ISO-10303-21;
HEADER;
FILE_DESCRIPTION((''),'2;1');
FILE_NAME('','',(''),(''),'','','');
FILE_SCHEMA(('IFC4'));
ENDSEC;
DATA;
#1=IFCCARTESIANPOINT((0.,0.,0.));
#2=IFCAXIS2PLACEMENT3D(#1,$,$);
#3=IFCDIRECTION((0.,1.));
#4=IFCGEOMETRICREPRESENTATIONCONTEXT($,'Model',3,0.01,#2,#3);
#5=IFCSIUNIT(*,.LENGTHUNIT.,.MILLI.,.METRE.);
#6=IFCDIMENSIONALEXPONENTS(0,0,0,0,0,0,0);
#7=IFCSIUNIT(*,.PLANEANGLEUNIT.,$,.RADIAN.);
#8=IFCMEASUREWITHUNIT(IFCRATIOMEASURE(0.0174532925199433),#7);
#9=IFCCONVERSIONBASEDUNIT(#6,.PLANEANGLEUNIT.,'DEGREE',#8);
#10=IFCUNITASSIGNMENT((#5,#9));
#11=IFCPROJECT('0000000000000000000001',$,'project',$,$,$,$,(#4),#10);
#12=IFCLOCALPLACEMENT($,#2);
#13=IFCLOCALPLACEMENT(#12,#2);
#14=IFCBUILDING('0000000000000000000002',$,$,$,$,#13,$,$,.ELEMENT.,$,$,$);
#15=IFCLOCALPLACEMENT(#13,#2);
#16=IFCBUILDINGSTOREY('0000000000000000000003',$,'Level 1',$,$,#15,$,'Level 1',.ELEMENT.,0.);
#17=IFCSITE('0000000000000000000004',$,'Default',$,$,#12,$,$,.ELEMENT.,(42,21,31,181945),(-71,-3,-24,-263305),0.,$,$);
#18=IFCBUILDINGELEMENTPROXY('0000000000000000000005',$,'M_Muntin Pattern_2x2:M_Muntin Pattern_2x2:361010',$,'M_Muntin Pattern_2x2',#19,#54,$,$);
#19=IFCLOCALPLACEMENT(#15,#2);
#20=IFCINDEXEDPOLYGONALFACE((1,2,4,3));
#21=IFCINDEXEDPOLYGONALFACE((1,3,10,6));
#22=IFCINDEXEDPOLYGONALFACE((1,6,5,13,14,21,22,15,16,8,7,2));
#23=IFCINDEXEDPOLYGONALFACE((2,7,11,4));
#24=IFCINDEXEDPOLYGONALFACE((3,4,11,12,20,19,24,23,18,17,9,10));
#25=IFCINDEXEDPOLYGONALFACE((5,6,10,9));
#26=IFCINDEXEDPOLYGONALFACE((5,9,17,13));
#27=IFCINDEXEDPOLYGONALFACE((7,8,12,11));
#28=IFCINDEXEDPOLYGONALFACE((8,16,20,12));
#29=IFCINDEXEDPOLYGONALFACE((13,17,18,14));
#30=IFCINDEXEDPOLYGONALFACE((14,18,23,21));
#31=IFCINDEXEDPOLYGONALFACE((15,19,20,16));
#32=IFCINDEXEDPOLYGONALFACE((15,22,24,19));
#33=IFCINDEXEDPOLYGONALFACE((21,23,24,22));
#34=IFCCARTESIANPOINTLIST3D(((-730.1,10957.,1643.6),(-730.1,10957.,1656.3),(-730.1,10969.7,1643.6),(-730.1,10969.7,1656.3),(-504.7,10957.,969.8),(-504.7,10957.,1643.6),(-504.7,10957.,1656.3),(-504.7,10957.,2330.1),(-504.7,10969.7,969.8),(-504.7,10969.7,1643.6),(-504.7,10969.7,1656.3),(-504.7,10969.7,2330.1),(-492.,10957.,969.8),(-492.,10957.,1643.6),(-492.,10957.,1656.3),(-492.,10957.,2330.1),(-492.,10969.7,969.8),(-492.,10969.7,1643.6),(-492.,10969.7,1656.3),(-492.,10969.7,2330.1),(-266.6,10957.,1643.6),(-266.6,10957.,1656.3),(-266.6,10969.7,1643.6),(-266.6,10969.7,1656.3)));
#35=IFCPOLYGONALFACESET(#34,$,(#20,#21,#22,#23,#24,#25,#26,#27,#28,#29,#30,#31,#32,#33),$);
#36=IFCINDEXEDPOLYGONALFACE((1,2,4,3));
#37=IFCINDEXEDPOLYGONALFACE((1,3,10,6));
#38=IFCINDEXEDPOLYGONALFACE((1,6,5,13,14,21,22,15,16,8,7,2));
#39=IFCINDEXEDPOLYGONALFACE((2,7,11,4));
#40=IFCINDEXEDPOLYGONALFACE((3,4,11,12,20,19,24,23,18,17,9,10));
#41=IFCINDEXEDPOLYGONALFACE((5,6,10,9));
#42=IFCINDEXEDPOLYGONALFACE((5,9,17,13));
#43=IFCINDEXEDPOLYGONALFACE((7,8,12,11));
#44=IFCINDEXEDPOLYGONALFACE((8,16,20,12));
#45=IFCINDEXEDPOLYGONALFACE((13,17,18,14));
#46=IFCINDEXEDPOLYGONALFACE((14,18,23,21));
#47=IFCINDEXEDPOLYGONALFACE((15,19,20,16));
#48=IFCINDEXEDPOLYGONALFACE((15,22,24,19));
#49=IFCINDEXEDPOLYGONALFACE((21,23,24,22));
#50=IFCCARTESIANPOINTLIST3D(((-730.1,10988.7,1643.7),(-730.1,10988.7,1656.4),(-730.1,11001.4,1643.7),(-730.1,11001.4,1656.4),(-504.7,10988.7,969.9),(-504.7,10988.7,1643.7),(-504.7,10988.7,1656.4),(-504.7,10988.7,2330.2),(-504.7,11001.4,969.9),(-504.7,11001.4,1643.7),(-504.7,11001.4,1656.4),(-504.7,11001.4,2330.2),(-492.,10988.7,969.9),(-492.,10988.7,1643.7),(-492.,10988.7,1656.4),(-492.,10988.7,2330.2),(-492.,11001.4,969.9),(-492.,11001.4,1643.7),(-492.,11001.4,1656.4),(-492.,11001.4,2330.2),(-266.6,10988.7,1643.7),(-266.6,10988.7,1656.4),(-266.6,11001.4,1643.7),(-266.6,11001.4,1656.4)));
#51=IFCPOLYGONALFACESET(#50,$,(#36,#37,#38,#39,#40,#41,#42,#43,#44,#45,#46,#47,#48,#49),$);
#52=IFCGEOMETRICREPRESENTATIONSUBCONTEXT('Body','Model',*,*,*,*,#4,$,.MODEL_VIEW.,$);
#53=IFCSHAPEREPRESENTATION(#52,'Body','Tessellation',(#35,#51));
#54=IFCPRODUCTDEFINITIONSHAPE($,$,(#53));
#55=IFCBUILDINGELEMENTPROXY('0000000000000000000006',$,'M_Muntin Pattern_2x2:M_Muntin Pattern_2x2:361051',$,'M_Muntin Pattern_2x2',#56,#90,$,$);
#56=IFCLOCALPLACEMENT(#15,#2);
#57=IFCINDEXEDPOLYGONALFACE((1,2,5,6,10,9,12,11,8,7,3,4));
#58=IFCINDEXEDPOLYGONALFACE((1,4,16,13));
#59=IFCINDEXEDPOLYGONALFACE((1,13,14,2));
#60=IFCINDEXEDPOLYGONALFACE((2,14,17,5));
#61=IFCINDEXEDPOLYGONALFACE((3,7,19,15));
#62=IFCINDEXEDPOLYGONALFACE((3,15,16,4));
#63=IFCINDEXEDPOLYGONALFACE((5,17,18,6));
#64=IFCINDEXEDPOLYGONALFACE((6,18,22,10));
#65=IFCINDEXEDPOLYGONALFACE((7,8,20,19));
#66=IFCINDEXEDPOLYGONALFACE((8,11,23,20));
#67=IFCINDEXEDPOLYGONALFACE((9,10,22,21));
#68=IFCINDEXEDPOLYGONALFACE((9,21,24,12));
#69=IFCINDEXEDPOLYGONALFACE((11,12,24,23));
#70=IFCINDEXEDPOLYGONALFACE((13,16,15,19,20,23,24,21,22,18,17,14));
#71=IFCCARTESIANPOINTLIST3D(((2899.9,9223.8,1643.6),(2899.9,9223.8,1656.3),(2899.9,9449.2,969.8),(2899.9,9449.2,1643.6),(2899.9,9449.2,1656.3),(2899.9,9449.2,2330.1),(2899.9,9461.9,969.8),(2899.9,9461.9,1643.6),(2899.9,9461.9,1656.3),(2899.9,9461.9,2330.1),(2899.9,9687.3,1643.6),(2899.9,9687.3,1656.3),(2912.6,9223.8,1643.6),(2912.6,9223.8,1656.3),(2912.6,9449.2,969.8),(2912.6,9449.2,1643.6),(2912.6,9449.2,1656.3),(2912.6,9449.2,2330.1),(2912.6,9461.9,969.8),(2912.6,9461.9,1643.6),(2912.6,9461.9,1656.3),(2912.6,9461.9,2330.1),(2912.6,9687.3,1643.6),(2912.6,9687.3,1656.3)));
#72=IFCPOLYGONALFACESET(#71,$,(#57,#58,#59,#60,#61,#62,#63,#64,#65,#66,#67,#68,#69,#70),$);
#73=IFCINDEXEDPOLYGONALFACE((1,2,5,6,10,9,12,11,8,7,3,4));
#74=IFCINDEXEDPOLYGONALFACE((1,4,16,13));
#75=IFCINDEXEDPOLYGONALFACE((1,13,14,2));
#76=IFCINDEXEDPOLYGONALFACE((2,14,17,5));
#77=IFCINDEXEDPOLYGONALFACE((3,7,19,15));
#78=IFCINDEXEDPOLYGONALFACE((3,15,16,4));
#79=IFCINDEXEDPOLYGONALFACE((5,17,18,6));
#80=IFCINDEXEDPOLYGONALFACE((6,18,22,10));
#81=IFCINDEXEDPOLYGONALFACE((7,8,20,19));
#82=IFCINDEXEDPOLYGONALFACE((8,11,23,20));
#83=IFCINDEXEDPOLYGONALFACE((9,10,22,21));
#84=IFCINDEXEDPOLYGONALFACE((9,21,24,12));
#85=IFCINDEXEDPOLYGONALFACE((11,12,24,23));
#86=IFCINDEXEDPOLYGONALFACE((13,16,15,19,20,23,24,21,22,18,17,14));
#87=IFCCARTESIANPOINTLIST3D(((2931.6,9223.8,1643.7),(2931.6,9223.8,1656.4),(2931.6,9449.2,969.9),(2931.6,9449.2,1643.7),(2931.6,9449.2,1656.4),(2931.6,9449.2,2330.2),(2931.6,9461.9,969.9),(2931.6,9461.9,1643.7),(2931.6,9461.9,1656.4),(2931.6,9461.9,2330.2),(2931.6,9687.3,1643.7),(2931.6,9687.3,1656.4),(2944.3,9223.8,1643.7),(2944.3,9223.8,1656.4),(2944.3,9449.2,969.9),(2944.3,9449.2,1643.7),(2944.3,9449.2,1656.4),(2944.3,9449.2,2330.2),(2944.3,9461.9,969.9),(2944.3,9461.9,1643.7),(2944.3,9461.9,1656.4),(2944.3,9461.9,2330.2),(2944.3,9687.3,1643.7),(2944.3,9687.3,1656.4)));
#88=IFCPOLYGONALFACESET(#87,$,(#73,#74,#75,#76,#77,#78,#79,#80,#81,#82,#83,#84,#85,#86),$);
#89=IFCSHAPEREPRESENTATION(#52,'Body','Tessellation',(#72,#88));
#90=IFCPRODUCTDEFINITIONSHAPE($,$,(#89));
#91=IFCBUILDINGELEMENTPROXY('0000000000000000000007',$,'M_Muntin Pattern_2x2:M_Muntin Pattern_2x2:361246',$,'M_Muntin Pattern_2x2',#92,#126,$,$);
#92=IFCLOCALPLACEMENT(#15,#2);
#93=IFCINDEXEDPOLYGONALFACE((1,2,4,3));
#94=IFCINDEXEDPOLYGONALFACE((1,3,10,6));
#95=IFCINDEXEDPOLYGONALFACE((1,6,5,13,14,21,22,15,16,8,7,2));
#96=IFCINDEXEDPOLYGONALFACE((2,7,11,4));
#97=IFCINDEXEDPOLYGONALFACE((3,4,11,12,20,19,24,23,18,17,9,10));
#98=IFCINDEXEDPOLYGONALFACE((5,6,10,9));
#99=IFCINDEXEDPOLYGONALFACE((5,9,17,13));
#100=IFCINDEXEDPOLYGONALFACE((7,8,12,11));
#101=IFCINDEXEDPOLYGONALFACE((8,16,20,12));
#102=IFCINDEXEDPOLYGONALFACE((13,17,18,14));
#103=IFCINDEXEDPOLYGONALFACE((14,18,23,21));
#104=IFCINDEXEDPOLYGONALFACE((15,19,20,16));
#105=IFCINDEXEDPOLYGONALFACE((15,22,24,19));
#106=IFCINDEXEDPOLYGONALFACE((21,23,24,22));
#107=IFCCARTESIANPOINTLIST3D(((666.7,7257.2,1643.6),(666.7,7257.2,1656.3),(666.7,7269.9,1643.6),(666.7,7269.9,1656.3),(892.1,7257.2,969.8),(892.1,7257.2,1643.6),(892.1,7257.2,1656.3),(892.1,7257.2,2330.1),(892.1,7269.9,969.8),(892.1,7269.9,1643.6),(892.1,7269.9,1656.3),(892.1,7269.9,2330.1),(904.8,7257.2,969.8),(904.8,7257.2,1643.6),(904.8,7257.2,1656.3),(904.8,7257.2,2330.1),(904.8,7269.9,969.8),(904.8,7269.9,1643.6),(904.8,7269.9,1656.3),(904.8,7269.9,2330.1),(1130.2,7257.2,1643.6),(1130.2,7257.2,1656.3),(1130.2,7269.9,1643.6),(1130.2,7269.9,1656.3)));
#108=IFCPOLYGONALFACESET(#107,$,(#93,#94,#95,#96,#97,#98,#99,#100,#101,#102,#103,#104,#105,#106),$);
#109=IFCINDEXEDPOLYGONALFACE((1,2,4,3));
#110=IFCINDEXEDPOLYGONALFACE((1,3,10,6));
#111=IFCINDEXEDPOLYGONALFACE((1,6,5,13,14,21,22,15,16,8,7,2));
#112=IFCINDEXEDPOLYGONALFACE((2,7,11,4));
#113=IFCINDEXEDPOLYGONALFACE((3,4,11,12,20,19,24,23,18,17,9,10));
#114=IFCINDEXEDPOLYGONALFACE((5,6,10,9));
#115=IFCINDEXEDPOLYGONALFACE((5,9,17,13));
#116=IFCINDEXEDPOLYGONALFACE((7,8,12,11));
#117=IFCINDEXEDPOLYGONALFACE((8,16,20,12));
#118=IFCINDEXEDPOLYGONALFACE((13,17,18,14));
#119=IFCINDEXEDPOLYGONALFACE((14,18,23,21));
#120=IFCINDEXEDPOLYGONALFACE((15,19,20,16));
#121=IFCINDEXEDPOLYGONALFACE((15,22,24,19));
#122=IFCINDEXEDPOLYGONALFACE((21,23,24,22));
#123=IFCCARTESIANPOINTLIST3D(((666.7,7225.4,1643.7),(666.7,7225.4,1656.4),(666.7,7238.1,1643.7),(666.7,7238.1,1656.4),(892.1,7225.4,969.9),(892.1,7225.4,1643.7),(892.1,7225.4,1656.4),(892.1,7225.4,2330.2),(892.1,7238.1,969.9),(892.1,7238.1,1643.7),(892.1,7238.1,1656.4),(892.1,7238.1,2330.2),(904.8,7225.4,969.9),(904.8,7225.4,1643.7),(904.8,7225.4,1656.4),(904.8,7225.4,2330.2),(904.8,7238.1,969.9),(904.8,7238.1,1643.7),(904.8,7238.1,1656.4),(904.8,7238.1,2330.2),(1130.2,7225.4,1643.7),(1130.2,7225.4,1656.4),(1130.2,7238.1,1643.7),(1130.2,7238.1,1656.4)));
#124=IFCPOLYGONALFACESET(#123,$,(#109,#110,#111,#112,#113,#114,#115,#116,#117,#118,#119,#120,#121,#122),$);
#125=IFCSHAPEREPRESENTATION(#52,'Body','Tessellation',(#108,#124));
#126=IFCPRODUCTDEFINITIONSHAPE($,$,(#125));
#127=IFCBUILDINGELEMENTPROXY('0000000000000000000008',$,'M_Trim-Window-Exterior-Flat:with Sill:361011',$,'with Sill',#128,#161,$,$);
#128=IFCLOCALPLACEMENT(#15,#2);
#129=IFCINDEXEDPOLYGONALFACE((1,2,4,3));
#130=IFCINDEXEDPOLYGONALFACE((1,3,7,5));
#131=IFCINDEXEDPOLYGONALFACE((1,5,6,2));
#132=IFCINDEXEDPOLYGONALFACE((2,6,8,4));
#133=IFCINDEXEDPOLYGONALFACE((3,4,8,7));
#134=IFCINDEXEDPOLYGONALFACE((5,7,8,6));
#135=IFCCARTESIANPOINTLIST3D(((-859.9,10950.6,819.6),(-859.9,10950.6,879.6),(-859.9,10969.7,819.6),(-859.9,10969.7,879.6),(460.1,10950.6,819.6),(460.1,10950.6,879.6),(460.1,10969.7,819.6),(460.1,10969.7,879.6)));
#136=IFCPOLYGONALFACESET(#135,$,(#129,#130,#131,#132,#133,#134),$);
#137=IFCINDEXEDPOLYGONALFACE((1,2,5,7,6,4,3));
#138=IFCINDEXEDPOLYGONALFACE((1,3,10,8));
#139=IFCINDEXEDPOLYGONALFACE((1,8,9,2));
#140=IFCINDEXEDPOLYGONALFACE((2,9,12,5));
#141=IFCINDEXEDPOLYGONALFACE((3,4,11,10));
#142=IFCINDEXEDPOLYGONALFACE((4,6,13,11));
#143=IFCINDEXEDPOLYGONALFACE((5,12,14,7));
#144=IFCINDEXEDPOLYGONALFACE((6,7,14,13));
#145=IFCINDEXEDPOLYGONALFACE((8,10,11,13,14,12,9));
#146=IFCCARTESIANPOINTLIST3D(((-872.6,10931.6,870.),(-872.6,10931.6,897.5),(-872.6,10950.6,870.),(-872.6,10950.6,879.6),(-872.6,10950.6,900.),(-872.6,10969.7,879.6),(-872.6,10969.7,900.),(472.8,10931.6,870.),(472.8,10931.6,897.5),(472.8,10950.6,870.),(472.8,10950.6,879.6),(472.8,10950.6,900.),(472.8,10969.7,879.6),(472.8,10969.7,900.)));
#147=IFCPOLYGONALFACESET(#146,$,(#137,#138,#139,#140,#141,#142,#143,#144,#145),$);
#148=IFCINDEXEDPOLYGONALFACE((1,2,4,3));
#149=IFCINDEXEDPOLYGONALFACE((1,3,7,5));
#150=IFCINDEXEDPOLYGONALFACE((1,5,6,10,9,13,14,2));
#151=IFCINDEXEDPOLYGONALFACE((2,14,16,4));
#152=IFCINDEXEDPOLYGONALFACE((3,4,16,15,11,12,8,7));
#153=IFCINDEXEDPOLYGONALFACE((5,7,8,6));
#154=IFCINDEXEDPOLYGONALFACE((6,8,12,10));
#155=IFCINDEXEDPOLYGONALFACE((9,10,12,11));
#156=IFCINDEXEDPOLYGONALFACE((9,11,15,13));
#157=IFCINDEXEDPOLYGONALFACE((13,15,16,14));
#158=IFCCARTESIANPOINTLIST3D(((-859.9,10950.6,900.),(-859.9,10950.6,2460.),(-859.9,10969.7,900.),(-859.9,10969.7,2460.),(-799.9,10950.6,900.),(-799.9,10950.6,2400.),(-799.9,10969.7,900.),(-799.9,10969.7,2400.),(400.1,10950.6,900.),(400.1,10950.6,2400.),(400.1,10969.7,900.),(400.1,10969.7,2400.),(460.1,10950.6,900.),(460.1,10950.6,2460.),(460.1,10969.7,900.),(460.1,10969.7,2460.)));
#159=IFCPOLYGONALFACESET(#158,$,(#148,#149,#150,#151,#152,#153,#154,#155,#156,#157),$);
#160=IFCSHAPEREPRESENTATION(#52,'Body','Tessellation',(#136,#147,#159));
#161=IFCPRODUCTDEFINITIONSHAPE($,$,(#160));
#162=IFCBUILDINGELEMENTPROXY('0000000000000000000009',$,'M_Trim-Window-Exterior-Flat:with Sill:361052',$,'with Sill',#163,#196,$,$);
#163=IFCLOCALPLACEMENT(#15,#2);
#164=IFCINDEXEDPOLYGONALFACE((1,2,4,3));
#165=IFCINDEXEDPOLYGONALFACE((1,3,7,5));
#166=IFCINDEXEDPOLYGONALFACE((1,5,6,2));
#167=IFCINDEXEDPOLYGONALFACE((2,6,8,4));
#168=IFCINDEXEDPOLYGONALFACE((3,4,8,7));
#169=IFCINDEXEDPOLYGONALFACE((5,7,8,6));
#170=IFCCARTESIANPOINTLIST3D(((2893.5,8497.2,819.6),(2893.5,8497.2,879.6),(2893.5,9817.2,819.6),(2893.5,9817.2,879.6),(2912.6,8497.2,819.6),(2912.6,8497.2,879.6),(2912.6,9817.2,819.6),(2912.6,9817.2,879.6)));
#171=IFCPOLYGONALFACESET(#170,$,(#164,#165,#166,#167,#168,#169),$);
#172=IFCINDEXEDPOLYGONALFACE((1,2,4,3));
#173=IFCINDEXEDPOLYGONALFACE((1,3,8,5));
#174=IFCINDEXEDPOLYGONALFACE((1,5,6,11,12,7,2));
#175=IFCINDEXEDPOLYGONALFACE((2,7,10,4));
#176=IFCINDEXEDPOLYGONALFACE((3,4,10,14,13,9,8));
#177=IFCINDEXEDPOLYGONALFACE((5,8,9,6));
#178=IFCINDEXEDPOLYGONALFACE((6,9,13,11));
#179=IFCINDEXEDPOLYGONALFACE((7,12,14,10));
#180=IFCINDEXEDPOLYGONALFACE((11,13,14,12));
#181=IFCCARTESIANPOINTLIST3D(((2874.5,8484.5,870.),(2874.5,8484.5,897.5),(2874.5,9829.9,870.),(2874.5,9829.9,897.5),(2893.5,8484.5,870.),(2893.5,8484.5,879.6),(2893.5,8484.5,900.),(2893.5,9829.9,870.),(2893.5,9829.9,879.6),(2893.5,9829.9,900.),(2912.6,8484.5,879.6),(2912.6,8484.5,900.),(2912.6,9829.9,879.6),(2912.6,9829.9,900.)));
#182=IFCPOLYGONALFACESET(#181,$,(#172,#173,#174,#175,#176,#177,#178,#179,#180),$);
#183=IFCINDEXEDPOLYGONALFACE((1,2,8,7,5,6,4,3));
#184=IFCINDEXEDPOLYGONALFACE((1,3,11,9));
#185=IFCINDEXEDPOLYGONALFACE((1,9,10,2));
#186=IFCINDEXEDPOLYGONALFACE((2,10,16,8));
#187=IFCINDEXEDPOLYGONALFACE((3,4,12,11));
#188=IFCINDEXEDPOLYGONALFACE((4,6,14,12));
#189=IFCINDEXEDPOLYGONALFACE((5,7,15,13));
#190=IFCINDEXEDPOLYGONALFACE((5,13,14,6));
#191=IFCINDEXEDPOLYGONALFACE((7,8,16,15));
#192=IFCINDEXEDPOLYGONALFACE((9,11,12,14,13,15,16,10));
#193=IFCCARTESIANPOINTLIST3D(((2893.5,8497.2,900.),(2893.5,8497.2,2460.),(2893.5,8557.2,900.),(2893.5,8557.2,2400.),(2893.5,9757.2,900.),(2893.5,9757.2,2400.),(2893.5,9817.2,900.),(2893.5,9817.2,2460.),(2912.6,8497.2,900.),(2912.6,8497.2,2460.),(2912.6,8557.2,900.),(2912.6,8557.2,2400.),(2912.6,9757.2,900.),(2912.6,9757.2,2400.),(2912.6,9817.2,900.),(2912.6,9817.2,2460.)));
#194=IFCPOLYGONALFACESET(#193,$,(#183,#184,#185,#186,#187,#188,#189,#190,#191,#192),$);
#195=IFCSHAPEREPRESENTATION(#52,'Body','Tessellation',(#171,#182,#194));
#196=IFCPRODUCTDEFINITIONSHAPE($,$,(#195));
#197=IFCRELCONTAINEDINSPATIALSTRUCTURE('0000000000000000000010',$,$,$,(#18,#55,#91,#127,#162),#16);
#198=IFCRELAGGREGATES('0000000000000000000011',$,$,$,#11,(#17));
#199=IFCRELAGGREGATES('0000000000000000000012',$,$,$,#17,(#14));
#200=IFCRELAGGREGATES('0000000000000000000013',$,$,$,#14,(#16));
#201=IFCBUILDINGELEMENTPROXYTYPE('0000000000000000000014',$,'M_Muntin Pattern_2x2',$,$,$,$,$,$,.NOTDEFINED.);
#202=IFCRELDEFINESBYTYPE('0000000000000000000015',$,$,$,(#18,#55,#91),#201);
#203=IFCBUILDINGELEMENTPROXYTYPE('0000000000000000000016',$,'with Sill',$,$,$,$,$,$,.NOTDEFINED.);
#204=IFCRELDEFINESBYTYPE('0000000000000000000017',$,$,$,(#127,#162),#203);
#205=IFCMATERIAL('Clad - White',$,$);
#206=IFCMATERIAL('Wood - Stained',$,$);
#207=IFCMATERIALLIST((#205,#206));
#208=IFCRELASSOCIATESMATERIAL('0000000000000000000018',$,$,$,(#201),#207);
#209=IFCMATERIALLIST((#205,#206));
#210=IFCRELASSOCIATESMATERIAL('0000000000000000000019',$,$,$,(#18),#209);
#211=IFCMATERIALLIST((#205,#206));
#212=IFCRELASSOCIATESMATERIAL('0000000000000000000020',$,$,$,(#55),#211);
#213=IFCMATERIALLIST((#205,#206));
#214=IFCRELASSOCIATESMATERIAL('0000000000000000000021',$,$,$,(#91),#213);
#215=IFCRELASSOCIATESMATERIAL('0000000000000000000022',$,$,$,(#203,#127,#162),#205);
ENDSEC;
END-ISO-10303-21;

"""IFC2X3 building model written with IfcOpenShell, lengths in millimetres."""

from ifc_helpers import new_model, entity, si_unit, converted_unit, direction, frame, frame_2d, origin, place, context, subcontext, project, spatial, polyline, rectangle, outline, extrude, source, transform, mapped, material, material_list, type_object, type_shapes, element, save


model = new_model("IFC2X3")

# Units and contexts
model_context = context("Model", 3, precision=0.01, world=origin(), true_north=direction((0.0, 1.0)))
body_context = subcontext(model_context, "Body", "Model", "MODEL_VIEW")
ifc_project = project(units=[si_unit("LENGTHUNIT", "METRE", prefix="MILLI"), converted_unit("PLANEANGLEUNIT", "DEGREE", entity("IfcRatioMeasure", 0.0174532925199433), si_unit("PLANEANGLEUNIT", "RADIAN"), dimensions=[0, 0, 0, 0, 0, 0, 0])], contexts=[model_context])

# Site, building, storey
site_placement = place(None, origin())
site = spatial("IfcSite", under=ifc_project, at=site_placement, Name="Default", CompositionType="ELEMENT", RefLatitude=(42, 21, 31, 181945), RefLongitude=(-71, -3, -24, -263305), RefElevation=0.0)
building_placement = place(site_placement, origin())
building = spatial("IfcBuilding", under=site, at=building_placement, CompositionType="ELEMENT")
storey_placement = place(building_placement, origin())
storey = spatial("IfcBuildingStorey", under=building, at=storey_placement, Name="Level 1", LongName="Level 1", CompositionType="ELEMENT", Elevation=0.0)

# Building element proxies
ifc_material_1 = material(Name="Clad - White")
ifc_material_2 = material(Name="Wood - Stained")
ifc_material_list_1 = material_list([ifc_material_1, ifc_material_2])
ifc_material_list_2 = material_list([ifc_material_1, ifc_material_2])
building_element_proxy_type_1 = type_object("IfcBuildingElementProxyType", Name="M_Muntin Pattern_2x2", PredefinedType="NOTDEFINED", material=ifc_material_list_2)
shared_shape_1 = source(origin(), body_context, "Body", "SweptSolid", [
    extrude(outline(polyline([(6.4, -6.4), (680.1, -6.4), (680.1, 6.3), (6.4, 6.3), (6.4, 231.7), (-6.3, 231.7), (-6.3, 6.3), (-680.2, 6.3), (-680.2, -6.4), (-6.3, -6.4), (-6.3, -231.7), (6.4, -231.7), (6.4, -6.4)])), frame((0.0, -22.2, 680.1), z_axis=(0.0, 1.0, 0.0), x_axis=(0.0, 0.0, 1.0)), (0.0, 0.0, 1.0), 12.7),
    extrude(outline(polyline([(6.4, -6.4), (680.1, -6.4), (680.1, 6.3), (6.4, 6.3), (6.4, 231.7), (-6.3, 231.7), (-6.3, 6.3), (-680.2, 6.3), (-680.2, -6.4), (-6.3, -6.4), (-6.3, -231.7), (6.4, -231.7), (6.4, -6.4)])), frame((0.0, 9.5, 680.2), z_axis=(0.0, 1.0, 0.0), x_axis=(0.0, 0.0, 1.0)), (0.0, 0.0, 1.0), 12.7),
])
type_shapes(building_element_proxy_type_1, [shared_shape_1])
proxy_1_placement = place(storey_placement, frame((-498.4, 10979.2, 969.9)))
element("IfcBuildingElementProxy", 1, at=proxy_1_placement, inside=storey, type_object=building_element_proxy_type_1, material=ifc_material_list_1, Name="M_Muntin Pattern_2x2:M_Muntin Pattern_2x2:361010", ObjectType="M_Muntin Pattern_2x2", context=body_context, shape_type="MappedRepresentation", body=[
    mapped(shared_shape_1, transform((0.0, 0.0, 0.0), scale=1.0)),
])
ifc_material_list_3 = material_list([ifc_material_1, ifc_material_2])
proxy_2_placement = place(storey_placement, frame((2922.1, 9455.6, 969.9), z_axis=(0.0, 0.0, 1.0), x_axis=(0.0, -1.0, 0.0)))
element("IfcBuildingElementProxy", 2, at=proxy_2_placement, inside=storey, type_object=building_element_proxy_type_1, material=ifc_material_list_3, Name="M_Muntin Pattern_2x2:M_Muntin Pattern_2x2:361051", ObjectType="M_Muntin Pattern_2x2", context=body_context, shape_type="MappedRepresentation", body=[
    mapped(shared_shape_1, transform((0.0, 0.0, 0.0), scale=1.0)),
])
ifc_material_list_4 = material_list([ifc_material_1, ifc_material_2])
proxy_3_placement = place(storey_placement, frame((898.5, 7247.6, 969.9), z_axis=(0.0, 0.0, 1.0), x_axis=(-1.0, 0.0, 0.0)))
element("IfcBuildingElementProxy", 3, at=proxy_3_placement, inside=storey, type_object=building_element_proxy_type_1, material=ifc_material_list_4, Name="M_Muntin Pattern_2x2:M_Muntin Pattern_2x2:361246", ObjectType="M_Muntin Pattern_2x2", context=body_context, shape_type="MappedRepresentation", body=[
    mapped(shared_shape_1, transform((0.0, 0.0, 0.0), scale=1.0)),
])
building_element_proxy_type_2 = type_object("IfcBuildingElementProxyType", Name="with Sill", PredefinedType="NOTDEFINED", material=ifc_material_1)
shared_shape_2 = source(origin(), body_context, "Body", "SweptSolid", [
    extrude(rectangle(XDim=1320.0, YDim=60.0, at=frame_2d((0.0, 0.0), x_axis=(1.0, 0.0))), frame((0.0, -1550.4, 0.0), z_axis=(0.0, 0.0, 1.0), x_axis=(-1.0, 0.0, 0.0)), (0.0, 0.0, 1.0), 19.1),
    extrude(outline(polyline([(-19.0, -15.2), (0.0, -15.2), (0.0, -5.7), (19.0, -5.7), (19.0, 14.8), (0.0, 14.8), (-19.0, 12.3), (-19.0, -15.2)])), frame((-672.7, -1514.8, 19.0), z_axis=(1.0, 0.0, 0.0), x_axis=(0.0, 0.0, -1.0)), (0.0, 0.0, 1.0), 1345.4),
    extrude(outline(polyline([(-795.0, -660.0), (765.0, -660.0), (765.0, -600.0), (-735.0, -600.0), (-735.0, 600.0), (765.0, 600.0), (765.0, 660.0), (-795.0, 660.0), (-795.0, -660.0)])), frame((0.0, -735.0, 0.0), z_axis=(0.0, 0.0, 1.0), x_axis=(0.0, -1.0, 0.0)), (0.0, 0.0, 1.0), 19.1),
])
type_shapes(building_element_proxy_type_2, [shared_shape_2])
for number, where, z_axis, x_axis, name in (
    (4, (-199.9, 10969.7, 2400.0), (0.0, -1.0, 0.0), (1.0, 0.0, 0.0), "M_Trim-Window-Exterior-Flat:with Sill:361011"),
    (5, (2912.6, 9157.2, 2400.0), (-1.0, 0.0, 0.0), (0.0, -1.0, 0.0), "M_Trim-Window-Exterior-Flat:with Sill:361052"),
):
    element("IfcBuildingElementProxy", number, at=place(storey_placement, frame(where, z_axis=z_axis, x_axis=x_axis)), inside=storey, type_object=building_element_proxy_type_2, material=ifc_material_1, Name=name, ObjectType="with Sill", context=body_context, shape_type="MappedRepresentation", body=[
        mapped(shared_shape_2, transform((0.0, 0.0, 0.0), scale=1.0)),
    ])

save(model, "model.ifc")
